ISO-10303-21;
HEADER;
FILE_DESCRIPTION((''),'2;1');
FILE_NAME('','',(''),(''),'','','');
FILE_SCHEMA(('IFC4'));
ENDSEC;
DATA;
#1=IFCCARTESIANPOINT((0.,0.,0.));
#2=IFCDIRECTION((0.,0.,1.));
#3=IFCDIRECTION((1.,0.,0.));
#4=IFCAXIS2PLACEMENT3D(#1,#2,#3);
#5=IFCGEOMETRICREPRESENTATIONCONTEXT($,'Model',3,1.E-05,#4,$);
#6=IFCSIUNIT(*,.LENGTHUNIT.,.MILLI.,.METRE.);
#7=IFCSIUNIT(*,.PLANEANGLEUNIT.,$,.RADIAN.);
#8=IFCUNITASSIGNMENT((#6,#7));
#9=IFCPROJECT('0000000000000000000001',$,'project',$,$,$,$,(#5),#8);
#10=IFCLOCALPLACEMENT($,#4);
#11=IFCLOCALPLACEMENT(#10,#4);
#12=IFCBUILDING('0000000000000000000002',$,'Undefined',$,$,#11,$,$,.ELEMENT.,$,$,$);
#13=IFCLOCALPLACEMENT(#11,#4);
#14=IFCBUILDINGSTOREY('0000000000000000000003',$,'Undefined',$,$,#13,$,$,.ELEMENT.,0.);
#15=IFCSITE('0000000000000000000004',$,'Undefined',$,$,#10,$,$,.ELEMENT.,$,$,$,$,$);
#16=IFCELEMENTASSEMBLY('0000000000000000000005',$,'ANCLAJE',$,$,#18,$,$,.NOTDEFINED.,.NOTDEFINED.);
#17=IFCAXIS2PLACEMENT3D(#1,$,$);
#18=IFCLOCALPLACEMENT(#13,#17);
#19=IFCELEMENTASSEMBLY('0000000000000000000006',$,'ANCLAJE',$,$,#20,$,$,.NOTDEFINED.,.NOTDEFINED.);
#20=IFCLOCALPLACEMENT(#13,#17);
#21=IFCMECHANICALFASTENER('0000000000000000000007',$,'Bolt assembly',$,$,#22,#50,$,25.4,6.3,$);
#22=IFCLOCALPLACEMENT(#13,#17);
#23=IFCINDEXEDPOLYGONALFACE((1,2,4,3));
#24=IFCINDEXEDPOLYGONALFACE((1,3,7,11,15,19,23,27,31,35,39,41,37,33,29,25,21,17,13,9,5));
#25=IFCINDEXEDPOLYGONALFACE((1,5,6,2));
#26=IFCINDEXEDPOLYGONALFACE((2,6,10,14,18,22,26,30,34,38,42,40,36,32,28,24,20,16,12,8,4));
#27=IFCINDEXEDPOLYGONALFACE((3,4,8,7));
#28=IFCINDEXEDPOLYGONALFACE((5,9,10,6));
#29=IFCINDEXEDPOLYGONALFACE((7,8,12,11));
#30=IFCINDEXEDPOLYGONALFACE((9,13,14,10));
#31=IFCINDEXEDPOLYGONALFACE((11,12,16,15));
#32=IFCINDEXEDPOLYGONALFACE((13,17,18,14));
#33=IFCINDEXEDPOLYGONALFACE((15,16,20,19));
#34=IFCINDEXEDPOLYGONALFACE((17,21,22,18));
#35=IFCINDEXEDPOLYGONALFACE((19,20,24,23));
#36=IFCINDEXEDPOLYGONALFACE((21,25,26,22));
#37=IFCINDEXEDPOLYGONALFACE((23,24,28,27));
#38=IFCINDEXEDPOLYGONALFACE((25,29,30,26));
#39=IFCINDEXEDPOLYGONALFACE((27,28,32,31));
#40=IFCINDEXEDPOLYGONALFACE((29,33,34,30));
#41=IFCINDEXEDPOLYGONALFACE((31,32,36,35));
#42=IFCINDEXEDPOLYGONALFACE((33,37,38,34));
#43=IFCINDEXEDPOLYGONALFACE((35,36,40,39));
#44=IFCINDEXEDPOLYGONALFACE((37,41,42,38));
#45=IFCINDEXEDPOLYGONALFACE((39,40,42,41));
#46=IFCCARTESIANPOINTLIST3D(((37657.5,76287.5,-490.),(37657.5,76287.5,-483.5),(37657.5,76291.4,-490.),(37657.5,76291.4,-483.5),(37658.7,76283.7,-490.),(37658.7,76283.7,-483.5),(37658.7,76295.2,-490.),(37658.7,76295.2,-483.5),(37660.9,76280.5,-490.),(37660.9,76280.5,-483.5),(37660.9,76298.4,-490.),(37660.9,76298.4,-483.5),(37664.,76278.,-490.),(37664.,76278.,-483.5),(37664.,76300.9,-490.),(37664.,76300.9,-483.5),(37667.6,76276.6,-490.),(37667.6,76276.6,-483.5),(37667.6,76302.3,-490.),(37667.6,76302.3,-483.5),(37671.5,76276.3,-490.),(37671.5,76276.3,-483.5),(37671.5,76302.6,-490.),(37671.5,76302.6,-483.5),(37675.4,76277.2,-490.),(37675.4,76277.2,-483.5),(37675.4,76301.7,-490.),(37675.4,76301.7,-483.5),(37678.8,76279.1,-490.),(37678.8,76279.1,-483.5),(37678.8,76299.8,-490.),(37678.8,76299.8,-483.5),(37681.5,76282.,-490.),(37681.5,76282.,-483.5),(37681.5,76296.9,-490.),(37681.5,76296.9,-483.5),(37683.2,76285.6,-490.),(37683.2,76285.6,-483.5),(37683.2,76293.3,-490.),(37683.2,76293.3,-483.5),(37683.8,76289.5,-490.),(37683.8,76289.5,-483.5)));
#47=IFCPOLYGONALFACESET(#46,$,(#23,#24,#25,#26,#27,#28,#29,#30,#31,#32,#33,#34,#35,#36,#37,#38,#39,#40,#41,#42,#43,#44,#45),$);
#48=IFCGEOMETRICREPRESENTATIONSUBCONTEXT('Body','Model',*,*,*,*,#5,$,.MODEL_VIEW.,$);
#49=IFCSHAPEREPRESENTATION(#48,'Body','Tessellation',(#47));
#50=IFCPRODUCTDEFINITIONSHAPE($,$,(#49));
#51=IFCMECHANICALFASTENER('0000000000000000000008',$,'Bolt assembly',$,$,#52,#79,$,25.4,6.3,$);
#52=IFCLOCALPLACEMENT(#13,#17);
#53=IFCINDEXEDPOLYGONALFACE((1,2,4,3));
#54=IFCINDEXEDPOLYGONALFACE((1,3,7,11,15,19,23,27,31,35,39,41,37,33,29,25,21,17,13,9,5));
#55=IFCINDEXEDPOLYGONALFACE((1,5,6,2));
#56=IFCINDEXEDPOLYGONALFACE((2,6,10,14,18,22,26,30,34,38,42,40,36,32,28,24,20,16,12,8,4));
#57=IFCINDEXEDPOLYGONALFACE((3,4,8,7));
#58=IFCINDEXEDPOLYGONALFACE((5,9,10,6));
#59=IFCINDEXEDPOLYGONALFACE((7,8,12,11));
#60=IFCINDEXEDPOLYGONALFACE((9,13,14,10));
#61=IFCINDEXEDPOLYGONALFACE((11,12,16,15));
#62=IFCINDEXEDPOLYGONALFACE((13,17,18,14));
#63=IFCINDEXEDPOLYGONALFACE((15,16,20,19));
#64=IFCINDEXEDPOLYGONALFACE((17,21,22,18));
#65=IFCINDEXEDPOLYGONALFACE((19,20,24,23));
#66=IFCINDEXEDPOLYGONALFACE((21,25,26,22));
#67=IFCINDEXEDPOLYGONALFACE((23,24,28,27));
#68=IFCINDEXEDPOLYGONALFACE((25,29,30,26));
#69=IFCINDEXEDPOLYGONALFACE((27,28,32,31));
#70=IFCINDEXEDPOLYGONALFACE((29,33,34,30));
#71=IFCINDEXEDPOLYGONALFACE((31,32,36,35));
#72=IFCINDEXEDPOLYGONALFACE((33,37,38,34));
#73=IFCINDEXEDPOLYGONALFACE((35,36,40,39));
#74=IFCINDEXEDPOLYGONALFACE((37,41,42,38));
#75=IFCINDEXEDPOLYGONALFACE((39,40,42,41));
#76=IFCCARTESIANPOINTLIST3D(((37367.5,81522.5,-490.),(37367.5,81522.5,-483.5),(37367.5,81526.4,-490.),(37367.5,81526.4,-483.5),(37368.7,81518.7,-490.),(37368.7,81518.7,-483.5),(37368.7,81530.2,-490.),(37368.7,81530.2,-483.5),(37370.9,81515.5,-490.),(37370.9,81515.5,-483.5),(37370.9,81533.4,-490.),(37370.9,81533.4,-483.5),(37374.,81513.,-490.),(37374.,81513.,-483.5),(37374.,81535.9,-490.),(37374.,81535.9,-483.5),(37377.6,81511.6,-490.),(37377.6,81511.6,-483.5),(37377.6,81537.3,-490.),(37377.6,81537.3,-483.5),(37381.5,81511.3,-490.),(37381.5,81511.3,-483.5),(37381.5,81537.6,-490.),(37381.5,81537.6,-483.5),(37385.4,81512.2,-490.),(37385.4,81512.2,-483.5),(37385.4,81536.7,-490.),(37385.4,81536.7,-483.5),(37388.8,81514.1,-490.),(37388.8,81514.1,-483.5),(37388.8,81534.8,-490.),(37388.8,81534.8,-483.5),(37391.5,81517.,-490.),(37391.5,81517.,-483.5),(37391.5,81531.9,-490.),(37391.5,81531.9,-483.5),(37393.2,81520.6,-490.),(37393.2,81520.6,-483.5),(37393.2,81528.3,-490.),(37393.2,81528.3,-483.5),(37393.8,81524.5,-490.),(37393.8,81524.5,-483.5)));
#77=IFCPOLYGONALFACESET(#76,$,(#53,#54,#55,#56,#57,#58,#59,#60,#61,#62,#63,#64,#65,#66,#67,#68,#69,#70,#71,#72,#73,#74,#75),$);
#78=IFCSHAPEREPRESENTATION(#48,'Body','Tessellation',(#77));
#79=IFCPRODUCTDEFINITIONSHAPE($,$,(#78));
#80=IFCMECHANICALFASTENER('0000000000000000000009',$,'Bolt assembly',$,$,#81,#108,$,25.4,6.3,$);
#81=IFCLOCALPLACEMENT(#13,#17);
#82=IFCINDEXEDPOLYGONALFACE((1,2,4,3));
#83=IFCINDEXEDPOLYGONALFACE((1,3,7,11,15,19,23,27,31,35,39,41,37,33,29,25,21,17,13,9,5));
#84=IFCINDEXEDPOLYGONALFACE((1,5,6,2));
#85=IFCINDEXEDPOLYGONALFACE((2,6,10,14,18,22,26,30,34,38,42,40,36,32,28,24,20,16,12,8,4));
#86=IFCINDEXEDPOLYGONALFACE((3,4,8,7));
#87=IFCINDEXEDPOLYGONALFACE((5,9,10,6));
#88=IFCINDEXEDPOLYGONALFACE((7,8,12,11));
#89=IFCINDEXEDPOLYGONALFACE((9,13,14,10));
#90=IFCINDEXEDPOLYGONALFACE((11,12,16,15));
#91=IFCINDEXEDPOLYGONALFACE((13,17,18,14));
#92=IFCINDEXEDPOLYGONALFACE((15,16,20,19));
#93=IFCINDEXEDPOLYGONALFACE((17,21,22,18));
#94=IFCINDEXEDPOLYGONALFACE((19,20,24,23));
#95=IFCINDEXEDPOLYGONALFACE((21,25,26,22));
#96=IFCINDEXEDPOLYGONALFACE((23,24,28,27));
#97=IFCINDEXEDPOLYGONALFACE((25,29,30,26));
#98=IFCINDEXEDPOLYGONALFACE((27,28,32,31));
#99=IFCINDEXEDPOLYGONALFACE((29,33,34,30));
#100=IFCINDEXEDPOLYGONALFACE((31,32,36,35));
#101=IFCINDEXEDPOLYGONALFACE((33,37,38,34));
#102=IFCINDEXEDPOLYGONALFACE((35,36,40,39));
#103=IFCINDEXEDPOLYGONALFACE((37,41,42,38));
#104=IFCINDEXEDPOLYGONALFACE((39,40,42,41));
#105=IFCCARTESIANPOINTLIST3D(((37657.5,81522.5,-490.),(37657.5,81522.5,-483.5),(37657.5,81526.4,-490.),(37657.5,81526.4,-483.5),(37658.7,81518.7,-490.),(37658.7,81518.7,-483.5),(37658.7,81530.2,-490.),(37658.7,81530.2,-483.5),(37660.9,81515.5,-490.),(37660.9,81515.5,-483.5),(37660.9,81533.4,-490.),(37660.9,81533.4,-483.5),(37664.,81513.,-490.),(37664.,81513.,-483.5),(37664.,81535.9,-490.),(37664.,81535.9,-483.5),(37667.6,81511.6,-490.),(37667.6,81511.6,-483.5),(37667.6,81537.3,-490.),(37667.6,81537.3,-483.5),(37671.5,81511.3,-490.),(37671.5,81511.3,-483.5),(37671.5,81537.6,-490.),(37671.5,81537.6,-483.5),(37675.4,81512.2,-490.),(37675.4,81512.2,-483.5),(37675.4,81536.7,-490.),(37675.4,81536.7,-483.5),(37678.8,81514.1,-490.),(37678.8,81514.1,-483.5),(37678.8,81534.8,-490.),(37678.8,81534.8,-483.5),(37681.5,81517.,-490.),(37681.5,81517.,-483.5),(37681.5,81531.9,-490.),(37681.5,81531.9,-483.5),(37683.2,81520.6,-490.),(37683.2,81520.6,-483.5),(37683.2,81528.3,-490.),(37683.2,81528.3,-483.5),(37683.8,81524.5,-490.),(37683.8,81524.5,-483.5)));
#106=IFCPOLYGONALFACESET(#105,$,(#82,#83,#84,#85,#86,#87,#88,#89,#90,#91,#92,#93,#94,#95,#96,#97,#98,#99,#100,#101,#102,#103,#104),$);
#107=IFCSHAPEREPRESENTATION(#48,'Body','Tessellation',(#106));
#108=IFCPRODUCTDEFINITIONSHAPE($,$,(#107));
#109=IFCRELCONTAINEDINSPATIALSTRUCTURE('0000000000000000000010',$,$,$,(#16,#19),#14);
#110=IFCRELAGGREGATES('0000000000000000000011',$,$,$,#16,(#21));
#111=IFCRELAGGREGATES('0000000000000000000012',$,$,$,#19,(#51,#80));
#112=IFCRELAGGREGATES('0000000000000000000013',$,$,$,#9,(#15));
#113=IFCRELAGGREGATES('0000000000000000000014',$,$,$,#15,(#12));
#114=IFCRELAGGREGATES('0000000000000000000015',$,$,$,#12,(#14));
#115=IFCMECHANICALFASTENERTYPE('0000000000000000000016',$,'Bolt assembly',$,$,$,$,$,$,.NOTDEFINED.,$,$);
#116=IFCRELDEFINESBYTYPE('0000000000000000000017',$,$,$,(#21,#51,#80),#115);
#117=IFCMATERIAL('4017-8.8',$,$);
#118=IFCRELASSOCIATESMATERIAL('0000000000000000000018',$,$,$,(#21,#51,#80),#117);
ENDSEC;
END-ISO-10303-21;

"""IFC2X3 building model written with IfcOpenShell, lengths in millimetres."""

from ifc_helpers import new_model, si_unit, frame, origin_with_axes, origin_2d_with_axis, place, context, subcontext, project, spatial, circle, extrude, source, transform, mapped, material, type_object, element, aggregate, save


model = new_model("IFC2X3")

# Units and contexts
model_context = context("Model", 3, precision=1e-05, world=origin_with_axes())
body_context = subcontext(model_context, "Body", "Model", "MODEL_VIEW")
ifc_project = project(units=[si_unit("LENGTHUNIT", "METRE", prefix="MILLI"), si_unit("PLANEANGLEUNIT", "RADIAN")], contexts=[model_context])

# Site, building, storey
site_placement = place(None, origin_with_axes())
site = spatial("IfcSite", under=ifc_project, at=site_placement, Name="Undefined", CompositionType="ELEMENT")
building_placement = place(site_placement, origin_with_axes())
building = spatial("IfcBuilding", under=site, at=building_placement, Name="Undefined", CompositionType="ELEMENT")
storey_placement = place(building_placement, origin_with_axes())
storey = spatial("IfcBuildingStorey", under=building, at=storey_placement, Name="Undefined", CompositionType="ELEMENT", Elevation=0.0)

# Element assemblies
assembly_1_placement = place(storey_placement, origin_with_axes())
assembly_1 = element("IfcElementAssembly", 1, at=assembly_1_placement, inside=storey, Name="ANCLAJE", AssemblyPlace="NOTDEFINED", PredefinedType="NOTDEFINED")
assembly_2_placement = place(storey_placement, origin_with_axes())
assembly_2 = element("IfcElementAssembly", 2, at=assembly_2_placement, inside=storey, Name="ANCLAJE", AssemblyPlace="NOTDEFINED", PredefinedType="NOTDEFINED")

# Mechanical fasteners
ifc_material_1 = material(Name="4017-8.8")
mechanical_fastener_type = type_object("IfcMechanicalFastenerType", Name="Bolt assembly")
shared_shape_1 = source(origin_with_axes(), body_context, "Body", "SweptSolid", [
    extrude(circle(Radius=13.2, at=origin_2d_with_axis()), frame((0.0, 0.0, 0.0), z_axis=(0.0, 1.0, 0.0), x_axis=(1.0, 0.0, 0.0)), (0.0, 0.0, 1.0), 6.5),
])
mechanical_fastener_1_placement = place(assembly_1_placement, frame((37670.6, 76289.5, -490.0), z_axis=(0.0, -1.0, 0.0), x_axis=(1.0, 0.0, 0.0)))
mechanical_fastener_1 = element("IfcMechanicalFastener", 3, at=mechanical_fastener_1_placement, type_object=mechanical_fastener_type, material=ifc_material_1, Name="Bolt assembly", NominalDiameter=25.4, NominalLength=6.3, context=body_context, shape_type="MappedRepresentation", body=[
    mapped(shared_shape_1, transform((0.0, 0.0, 0.0))),
])
aggregate(assembly_1, [mechanical_fastener_1])
mechanical_fastener_2_placement = place(assembly_2_placement, frame((37380.6, 81524.5, -490.0), z_axis=(0.0, -1.0, 0.0), x_axis=(1.0, 0.0, 0.0)))
mechanical_fastener_2 = element("IfcMechanicalFastener", 4, at=mechanical_fastener_2_placement, type_object=mechanical_fastener_type, material=ifc_material_1, Name="Bolt assembly", NominalDiameter=25.4, NominalLength=6.3, context=body_context, shape_type="MappedRepresentation", body=[
    mapped(shared_shape_1, transform((0.0, 0.0, 0.0))),
])
mechanical_fastener_3_placement = place(assembly_2_placement, frame((37670.6, 81524.5, -490.0), z_axis=(0.0, -1.0, 0.0), x_axis=(1.0, 0.0, 0.0)))
mechanical_fastener_3 = element("IfcMechanicalFastener", 5, at=mechanical_fastener_3_placement, type_object=mechanical_fastener_type, material=ifc_material_1, Name="Bolt assembly", NominalDiameter=25.4, NominalLength=6.3, context=body_context, shape_type="MappedRepresentation", body=[
    mapped(shared_shape_1, transform((0.0, 0.0, 0.0))),
])
aggregate(assembly_2, [mechanical_fastener_2, mechanical_fastener_3])

save(model, "model.ifc")
